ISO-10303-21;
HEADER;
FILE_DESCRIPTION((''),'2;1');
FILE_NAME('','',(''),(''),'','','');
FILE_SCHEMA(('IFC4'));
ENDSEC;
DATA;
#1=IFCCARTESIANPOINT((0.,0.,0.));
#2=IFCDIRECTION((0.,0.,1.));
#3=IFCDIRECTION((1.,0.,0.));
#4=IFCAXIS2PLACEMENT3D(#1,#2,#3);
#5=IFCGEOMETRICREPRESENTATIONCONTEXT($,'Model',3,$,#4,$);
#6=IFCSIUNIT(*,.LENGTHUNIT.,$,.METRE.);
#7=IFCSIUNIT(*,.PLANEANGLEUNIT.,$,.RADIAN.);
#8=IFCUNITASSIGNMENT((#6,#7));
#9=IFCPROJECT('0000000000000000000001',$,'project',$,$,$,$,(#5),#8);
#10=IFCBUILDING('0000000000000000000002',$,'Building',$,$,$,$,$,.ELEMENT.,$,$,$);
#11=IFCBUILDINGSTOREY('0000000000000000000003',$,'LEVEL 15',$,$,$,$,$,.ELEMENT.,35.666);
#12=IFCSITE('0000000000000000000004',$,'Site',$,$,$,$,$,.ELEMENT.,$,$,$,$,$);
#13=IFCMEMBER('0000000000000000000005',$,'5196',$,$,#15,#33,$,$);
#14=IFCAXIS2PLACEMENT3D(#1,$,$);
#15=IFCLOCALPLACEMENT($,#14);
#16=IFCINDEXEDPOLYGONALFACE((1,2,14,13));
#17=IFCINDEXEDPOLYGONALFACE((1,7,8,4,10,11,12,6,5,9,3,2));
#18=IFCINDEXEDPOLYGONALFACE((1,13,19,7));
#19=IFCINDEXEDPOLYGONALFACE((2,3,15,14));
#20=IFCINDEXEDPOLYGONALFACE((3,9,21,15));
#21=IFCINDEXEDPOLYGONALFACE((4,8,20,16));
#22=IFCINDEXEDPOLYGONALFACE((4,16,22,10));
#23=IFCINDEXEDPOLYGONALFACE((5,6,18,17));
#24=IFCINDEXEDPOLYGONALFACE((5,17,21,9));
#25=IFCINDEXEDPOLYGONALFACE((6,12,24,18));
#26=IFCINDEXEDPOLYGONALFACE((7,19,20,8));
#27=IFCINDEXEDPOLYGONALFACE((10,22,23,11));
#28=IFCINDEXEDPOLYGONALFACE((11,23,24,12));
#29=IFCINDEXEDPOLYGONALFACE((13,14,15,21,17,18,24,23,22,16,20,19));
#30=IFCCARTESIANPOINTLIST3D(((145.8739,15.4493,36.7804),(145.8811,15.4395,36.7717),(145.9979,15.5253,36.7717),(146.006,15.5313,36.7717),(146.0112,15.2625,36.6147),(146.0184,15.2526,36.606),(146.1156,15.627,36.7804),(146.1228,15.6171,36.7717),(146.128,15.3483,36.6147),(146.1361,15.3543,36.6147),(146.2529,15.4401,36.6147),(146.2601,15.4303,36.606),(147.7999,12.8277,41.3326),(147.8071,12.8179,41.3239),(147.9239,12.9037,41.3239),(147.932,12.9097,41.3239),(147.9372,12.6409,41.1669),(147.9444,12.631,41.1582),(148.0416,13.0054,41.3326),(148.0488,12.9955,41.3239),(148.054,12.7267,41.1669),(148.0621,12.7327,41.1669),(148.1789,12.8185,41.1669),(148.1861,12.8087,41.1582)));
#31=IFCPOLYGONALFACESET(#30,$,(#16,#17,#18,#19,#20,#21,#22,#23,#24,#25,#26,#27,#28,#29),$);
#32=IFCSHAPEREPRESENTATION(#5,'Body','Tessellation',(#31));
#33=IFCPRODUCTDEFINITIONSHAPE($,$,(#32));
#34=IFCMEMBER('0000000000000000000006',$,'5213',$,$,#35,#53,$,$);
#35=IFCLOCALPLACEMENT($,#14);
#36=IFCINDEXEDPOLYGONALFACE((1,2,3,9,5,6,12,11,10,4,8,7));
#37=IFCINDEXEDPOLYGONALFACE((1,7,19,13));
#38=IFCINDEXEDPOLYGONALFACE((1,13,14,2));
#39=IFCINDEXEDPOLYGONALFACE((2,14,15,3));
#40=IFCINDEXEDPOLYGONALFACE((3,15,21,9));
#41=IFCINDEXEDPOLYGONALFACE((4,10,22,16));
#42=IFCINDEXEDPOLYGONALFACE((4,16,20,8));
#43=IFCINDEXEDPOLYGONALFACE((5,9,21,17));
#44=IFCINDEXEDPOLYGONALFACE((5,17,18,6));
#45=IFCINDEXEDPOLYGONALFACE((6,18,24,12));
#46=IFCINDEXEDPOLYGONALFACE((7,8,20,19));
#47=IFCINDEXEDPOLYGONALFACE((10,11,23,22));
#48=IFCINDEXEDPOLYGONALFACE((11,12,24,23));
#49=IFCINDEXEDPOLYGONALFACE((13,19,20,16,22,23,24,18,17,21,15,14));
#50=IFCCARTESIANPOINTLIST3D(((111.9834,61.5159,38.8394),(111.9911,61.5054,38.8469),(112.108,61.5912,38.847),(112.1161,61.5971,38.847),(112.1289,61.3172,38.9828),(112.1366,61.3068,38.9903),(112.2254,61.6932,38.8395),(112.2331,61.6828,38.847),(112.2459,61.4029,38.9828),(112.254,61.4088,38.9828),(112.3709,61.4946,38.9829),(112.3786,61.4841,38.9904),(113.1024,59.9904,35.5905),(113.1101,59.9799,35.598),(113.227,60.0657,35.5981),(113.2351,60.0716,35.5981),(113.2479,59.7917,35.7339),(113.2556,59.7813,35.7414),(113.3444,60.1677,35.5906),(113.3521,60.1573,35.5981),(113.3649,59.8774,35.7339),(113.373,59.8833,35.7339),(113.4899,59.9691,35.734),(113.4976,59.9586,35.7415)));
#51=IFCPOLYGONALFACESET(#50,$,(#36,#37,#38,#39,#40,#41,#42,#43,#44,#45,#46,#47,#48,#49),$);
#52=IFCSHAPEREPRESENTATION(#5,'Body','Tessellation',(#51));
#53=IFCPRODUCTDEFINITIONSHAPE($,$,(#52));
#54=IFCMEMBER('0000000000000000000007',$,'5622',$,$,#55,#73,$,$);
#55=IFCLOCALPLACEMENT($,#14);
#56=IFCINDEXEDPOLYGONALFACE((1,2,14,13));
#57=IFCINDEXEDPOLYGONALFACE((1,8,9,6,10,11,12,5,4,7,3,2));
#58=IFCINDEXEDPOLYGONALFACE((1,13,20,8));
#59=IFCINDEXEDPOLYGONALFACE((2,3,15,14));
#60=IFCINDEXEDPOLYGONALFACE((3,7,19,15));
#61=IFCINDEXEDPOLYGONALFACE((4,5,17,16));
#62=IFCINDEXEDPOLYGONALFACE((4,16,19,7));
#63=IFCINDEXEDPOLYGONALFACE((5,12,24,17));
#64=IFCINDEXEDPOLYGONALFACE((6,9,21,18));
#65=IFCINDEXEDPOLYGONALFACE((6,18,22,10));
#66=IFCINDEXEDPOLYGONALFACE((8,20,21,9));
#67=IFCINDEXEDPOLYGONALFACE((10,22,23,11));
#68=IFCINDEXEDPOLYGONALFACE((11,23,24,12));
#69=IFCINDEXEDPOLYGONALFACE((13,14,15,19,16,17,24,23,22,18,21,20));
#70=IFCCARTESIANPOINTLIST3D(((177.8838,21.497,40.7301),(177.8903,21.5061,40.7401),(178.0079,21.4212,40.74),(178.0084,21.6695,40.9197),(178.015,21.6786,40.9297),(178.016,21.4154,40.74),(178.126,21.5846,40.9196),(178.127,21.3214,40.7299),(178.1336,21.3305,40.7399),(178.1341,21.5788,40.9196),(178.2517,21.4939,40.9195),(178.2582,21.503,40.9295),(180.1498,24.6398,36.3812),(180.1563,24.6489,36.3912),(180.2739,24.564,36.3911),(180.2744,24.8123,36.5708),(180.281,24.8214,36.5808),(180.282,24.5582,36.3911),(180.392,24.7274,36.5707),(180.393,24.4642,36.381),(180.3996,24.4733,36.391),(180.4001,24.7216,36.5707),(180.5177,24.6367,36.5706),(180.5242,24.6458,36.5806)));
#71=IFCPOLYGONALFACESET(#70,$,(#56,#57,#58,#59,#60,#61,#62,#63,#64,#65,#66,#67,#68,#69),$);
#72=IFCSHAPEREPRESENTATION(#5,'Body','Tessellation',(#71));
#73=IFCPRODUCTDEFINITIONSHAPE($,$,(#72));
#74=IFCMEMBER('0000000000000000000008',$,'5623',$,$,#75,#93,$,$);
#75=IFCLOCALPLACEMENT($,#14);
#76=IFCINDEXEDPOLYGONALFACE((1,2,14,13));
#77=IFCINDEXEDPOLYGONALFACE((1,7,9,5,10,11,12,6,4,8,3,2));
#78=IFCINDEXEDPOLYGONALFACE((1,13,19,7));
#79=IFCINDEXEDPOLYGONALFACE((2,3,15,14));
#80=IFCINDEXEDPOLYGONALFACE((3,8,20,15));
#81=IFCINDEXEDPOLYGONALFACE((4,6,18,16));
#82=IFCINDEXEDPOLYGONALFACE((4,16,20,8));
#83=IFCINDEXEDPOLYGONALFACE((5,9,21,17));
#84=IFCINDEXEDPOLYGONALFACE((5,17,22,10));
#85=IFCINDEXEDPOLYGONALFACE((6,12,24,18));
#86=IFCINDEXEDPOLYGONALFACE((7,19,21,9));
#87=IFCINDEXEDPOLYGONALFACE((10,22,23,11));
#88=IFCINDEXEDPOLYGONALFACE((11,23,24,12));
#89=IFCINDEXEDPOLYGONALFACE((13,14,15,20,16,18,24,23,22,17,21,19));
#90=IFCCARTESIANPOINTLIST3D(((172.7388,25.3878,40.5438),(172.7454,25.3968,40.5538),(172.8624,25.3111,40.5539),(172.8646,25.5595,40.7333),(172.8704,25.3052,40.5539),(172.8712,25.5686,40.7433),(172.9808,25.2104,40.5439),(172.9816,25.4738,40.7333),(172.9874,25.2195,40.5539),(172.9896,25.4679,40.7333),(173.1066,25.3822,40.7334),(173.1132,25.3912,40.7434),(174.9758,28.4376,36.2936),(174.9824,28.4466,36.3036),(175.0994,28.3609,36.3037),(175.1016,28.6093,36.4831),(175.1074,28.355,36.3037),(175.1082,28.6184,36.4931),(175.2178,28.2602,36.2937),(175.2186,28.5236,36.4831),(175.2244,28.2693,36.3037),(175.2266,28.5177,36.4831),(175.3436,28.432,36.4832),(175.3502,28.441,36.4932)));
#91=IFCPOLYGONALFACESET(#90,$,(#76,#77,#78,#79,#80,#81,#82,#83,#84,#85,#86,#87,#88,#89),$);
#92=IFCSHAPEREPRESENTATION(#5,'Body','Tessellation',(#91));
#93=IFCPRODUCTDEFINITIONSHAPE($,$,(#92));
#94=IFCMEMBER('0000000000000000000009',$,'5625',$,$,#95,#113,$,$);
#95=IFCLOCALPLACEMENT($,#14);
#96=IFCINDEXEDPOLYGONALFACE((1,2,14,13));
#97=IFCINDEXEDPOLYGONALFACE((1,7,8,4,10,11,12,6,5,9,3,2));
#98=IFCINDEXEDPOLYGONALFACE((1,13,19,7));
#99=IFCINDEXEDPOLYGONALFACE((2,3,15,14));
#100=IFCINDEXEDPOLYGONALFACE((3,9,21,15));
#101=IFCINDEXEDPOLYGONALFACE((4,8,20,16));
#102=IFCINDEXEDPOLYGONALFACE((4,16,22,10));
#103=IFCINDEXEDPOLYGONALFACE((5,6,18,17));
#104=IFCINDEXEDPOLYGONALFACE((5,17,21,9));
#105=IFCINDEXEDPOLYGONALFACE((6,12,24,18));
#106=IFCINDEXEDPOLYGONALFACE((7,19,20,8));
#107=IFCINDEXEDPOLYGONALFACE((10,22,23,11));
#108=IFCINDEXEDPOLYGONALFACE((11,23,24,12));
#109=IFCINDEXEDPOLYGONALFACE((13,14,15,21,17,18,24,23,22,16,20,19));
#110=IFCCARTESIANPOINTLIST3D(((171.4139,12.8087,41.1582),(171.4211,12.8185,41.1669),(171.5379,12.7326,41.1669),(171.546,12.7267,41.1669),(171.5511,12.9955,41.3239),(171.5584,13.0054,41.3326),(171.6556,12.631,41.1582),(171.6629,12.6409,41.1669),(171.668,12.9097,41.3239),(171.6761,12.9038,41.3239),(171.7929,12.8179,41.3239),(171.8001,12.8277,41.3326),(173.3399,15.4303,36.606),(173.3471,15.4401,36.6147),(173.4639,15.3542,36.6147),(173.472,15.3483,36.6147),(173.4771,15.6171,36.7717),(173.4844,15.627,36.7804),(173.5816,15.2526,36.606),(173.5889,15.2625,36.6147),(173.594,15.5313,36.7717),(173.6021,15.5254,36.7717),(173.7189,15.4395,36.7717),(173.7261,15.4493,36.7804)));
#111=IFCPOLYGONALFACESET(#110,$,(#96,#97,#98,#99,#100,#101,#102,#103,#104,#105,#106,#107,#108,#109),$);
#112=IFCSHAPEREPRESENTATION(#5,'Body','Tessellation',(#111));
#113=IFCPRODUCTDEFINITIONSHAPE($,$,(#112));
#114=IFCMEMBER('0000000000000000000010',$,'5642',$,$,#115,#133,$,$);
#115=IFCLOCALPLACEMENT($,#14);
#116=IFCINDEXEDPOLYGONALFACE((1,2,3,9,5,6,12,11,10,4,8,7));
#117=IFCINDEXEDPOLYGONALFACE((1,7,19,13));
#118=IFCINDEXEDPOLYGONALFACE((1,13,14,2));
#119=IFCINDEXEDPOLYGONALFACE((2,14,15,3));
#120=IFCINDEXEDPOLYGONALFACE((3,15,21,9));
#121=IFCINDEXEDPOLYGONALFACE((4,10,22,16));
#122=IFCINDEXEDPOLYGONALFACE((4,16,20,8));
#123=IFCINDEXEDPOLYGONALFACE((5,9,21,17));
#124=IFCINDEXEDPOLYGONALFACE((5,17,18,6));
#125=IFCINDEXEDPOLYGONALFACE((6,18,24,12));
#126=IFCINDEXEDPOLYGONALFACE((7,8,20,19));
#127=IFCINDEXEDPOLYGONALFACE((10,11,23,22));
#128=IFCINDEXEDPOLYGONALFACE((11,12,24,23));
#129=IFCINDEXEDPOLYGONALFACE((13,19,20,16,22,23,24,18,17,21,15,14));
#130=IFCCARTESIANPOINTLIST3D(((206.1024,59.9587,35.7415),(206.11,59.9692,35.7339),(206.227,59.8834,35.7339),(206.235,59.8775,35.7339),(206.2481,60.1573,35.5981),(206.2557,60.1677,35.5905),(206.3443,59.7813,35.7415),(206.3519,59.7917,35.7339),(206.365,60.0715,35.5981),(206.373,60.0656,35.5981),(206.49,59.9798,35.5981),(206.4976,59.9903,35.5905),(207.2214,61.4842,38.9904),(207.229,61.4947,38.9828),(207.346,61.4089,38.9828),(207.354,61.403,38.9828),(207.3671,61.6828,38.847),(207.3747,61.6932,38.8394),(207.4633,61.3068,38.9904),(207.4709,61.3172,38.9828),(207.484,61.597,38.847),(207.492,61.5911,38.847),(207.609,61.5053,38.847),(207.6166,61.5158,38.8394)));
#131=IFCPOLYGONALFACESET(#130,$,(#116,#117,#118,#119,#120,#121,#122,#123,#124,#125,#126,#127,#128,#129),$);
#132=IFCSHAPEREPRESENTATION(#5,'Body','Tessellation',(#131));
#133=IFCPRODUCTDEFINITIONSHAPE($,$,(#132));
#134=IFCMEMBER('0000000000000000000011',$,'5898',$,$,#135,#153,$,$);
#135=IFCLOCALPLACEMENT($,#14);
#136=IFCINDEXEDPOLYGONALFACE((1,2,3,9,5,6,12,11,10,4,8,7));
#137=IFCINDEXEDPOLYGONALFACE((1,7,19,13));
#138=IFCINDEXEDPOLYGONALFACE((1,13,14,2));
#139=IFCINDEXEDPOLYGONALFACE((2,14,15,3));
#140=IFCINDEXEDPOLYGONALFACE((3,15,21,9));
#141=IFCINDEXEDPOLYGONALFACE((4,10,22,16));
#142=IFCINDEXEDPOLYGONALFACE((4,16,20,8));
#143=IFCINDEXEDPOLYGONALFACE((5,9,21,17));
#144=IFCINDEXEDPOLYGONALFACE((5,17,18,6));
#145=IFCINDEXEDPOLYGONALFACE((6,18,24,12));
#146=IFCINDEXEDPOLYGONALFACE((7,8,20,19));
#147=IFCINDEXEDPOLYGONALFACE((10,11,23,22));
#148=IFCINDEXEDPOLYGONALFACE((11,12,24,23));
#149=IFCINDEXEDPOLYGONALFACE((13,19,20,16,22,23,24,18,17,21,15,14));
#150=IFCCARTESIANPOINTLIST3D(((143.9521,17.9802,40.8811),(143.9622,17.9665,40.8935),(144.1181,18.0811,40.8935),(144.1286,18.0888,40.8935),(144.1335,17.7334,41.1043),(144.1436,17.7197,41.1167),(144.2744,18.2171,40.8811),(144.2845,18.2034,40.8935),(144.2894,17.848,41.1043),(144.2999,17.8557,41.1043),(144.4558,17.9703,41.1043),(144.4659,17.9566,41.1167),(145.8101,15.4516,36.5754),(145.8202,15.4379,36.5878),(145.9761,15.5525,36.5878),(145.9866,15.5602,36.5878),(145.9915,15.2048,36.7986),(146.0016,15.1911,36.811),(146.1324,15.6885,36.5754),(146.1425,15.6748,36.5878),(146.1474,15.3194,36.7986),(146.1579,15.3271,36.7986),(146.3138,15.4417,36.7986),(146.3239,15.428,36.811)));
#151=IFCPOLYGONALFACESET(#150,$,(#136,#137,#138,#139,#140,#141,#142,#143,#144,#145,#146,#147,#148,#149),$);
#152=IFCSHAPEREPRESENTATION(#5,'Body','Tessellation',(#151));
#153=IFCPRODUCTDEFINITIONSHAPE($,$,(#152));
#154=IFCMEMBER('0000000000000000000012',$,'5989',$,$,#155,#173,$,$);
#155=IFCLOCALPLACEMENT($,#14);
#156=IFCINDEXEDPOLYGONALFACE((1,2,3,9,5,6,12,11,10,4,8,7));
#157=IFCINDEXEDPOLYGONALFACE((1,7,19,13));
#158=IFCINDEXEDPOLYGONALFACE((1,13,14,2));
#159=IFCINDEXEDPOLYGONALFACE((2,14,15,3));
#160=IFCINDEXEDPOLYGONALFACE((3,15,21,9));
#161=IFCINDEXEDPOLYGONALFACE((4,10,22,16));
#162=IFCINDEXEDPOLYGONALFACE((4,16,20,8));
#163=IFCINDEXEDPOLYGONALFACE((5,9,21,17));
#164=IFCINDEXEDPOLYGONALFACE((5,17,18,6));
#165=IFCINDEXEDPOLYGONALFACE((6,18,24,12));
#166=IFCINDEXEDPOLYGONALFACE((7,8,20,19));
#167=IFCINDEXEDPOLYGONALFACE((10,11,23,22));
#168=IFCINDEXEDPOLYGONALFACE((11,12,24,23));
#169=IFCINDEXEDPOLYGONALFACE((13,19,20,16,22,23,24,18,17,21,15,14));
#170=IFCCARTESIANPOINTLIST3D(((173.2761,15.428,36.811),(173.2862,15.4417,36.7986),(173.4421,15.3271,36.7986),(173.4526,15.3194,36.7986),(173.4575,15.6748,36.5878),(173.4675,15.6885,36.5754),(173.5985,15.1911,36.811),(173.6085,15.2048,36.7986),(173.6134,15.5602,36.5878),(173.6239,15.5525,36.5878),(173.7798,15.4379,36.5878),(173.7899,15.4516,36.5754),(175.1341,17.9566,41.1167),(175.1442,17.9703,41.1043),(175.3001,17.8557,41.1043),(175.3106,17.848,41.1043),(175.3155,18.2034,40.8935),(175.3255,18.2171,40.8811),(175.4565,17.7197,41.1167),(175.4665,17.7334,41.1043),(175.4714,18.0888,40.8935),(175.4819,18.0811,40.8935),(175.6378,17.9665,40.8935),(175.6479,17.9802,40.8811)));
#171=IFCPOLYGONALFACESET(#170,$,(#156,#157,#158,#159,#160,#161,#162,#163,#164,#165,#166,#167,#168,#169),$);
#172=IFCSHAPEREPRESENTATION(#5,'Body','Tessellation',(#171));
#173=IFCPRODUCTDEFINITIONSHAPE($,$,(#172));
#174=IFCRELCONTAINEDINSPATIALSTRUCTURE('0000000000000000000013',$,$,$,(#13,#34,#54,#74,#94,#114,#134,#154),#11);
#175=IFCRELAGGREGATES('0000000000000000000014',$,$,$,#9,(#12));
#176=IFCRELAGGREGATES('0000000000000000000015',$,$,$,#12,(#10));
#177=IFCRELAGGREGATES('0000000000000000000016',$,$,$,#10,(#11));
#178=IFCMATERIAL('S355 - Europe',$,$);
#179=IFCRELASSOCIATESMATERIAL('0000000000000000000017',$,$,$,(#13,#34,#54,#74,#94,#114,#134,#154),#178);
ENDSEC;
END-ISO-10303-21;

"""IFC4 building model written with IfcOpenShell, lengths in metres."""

from ifc_helpers import new_model, si_unit, frame, origin_with_axes, origin_2d_with_axis, place, context, project, spatial, i_section, extrude, material, material_profile, profile_set, profile_usage, element, save


model = new_model("IFC4")

# Units and contexts
model_context = context("Model", 3, world=origin_with_axes())
ifc_project = project(units=[si_unit("LENGTHUNIT", "METRE"), si_unit("PLANEANGLEUNIT", "RADIAN")], contexts=[model_context])

# Site, building, storey
site = spatial("IfcSite", under=ifc_project, Name="Site", CompositionType="ELEMENT")
building = spatial("IfcBuilding", under=site, Name="Building", CompositionType="ELEMENT")
storey = spatial("IfcBuildingStorey", under=building, Name="LEVEL 15", CompositionType="ELEMENT", Elevation=35.666)

# Shared definitions
ifc_material = material(Name="S355 - Europe")

# Members
ifc_material_profile_1 = material_profile(ifc_material, i_section(OverallWidth=0.3, OverallDepth=0.3, WebThickness=0.01, FlangeThickness=0.015, at=origin_2d_with_axis()))
ifc_profile_set_1 = profile_set([ifc_material_profile_1])
ifc_profile_usage_1 = profile_usage(ifc_profile_set_1, cardinal=10)
member_1_placement = place(None, frame((146.067, 15.4398, 36.6932), z_axis=(0.344232, -0.468556, 0.813609), x_axis=(0.805798, 0.59219, 0.0)))
element("IfcMember", 1, at=member_1_placement, inside=storey, material=ifc_profile_usage_1, Name="5196", context=model_context, shape_type="SweptSolid", body=[
    extrude(i_section(OverallWidth=0.3, OverallDepth=0.3, WebThickness=0.01, FlangeThickness=0.015, at=origin_2d_with_axis()), origin_with_axes(), (0.0, 0.0, 1.0), 5.5951),
])
ifc_material_profile_2 = material_profile(ifc_material, i_section(OverallWidth=0.3, OverallDepth=0.3, WebThickness=0.01, FlangeThickness=0.015, at=origin_2d_with_axis()))
ifc_profile_set_2 = profile_set([ifc_material_profile_2])
ifc_profile_usage_2 = profile_usage(ifc_profile_set_2, cardinal=10)
member_2_placement = place(None, frame((113.3, 59.9745, 35.666), z_axis=(-0.297637, 0.40576, 0.864159), x_axis=(-0.806706, -0.590953, 0.0)))
element("IfcMember", 2, at=member_2_placement, inside=storey, material=ifc_profile_usage_2, Name="5213", context=model_context, shape_type="SweptSolid", body=[
    extrude(i_section(OverallWidth=0.3, OverallDepth=0.3, WebThickness=0.01, FlangeThickness=0.015, at=origin_2d_with_axis()), origin_with_axes(), (0.0, 0.0, 1.0), 3.7596),
])
ifc_material_profile_3 = material_profile(ifc_material, i_section(OverallWidth=0.3, OverallDepth=0.3, WebThickness=0.01, FlangeThickness=0.015, at=origin_2d_with_axis()))
ifc_profile_set_3 = profile_set([ifc_material_profile_3])
ifc_profile_usage_3 = profile_usage(ifc_profile_set_3, cardinal=10)
member_3_placement = place(None, frame((180.337, 24.6428, 36.4809), z_axis=(-0.389046, -0.539582, 0.746656), x_axis=(0.810475, -0.585773, 0.0)))
element("IfcMember", 3, at=member_3_placement, inside=storey, material=ifc_profile_usage_3, Name="5622", context=model_context, shape_type="SweptSolid", body=[
    extrude(i_section(OverallWidth=0.3, OverallDepth=0.3, WebThickness=0.01, FlangeThickness=0.015, at=origin_2d_with_axis()), origin_with_axes(), (0.0, 0.0, 1.0), 5.8245),
])
ifc_material_profile_4 = material_profile(ifc_material, i_section(OverallWidth=0.3, OverallDepth=0.3, WebThickness=0.01, FlangeThickness=0.015, at=origin_2d_with_axis()))
ifc_profile_set_4 = profile_set([ifc_material_profile_4])
ifc_profile_usage_4 = profile_usage(ifc_profile_set_4, cardinal=10)
member_4_placement = place(None, frame((175.163, 28.4393, 36.3934), z_axis=(-0.393185, -0.536046, 0.747034), x_axis=(0.806706, -0.590953, 0.0)))
element("IfcMember", 4, at=member_4_placement, inside=storey, material=ifc_profile_usage_4, Name="5623", context=model_context, shape_type="SweptSolid", body=[
    extrude(i_section(OverallWidth=0.3, OverallDepth=0.3, WebThickness=0.01, FlangeThickness=0.015, at=origin_2d_with_axis()), origin_with_axes(), (0.0, 0.0, 1.0), 5.6894),
])
ifc_material_profile_5 = material_profile(ifc_material, i_section(OverallWidth=0.3, OverallDepth=0.3, WebThickness=0.01, FlangeThickness=0.015, at=origin_2d_with_axis()))
ifc_profile_set_5 = profile_set([ifc_material_profile_5])
ifc_profile_usage_5 = profile_usage(ifc_profile_set_5, cardinal=10)
member_5_placement = place(None, frame((173.533, 15.4398, 36.6932), z_axis=(-0.344232, -0.468556, 0.813609), x_axis=(0.805899, -0.592052, 0.0)))
element("IfcMember", 5, at=member_5_placement, inside=storey, material=ifc_profile_usage_5, Name="5625", context=model_context, shape_type="SweptSolid", body=[
    extrude(i_section(OverallWidth=0.3, OverallDepth=0.3, WebThickness=0.01, FlangeThickness=0.015, at=origin_2d_with_axis()), origin_with_axes(), (0.0, 0.0, 1.0), 5.5951),
])
ifc_material_profile_6 = material_profile(ifc_material, i_section(OverallWidth=0.3, OverallDepth=0.3, WebThickness=0.01, FlangeThickness=0.015, at=origin_2d_with_axis()))
ifc_profile_set_6 = profile_set([ifc_material_profile_6])
ifc_profile_usage_6 = profile_usage(ifc_profile_set_6, cardinal=10)
member_6_placement = place(None, frame((206.3, 59.9745, 35.666), z_axis=(0.297637, 0.40576, 0.864159), x_axis=(-0.806237, 0.591593, 0.0)))
element("IfcMember", 6, at=member_6_placement, inside=storey, material=ifc_profile_usage_6, Name="5642", context=model_context, shape_type="SweptSolid", body=[
    extrude(i_section(OverallWidth=0.3, OverallDepth=0.3, WebThickness=0.01, FlangeThickness=0.015, at=origin_2d_with_axis()), origin_with_axes(), (0.0, 0.0, 1.0), 3.7596),
])
ifc_material_profile_7 = material_profile(ifc_material, i_section(OverallWidth=0.4, OverallDepth=0.4, WebThickness=0.013, FlangeThickness=0.021, at=origin_2d_with_axis()))
ifc_profile_set_7 = profile_set([ifc_material_profile_7])
ifc_profile_usage_7 = profile_usage(ifc_profile_set_7, cardinal=10)
member_7_placement = place(None, frame((146.067, 15.4398, 36.6932), z_axis=(-0.348739, 0.474608, 0.808163), x_axis=(-0.805765, -0.592235, 0.0)))
element("IfcMember", 7, at=member_7_placement, inside=storey, material=ifc_profile_usage_7, Name="5898", context=model_context, shape_type="SweptSolid", body=[
    extrude(i_section(OverallWidth=0.4, OverallDepth=0.4, WebThickness=0.013, FlangeThickness=0.021, at=origin_2d_with_axis()), origin_with_axes(), (0.0, 0.0, 1.0), 5.3278),
])
ifc_material_profile_8 = material_profile(ifc_material, i_section(OverallWidth=0.4, OverallDepth=0.4, WebThickness=0.013, FlangeThickness=0.021, at=origin_2d_with_axis()))
ifc_profile_set_8 = profile_set([ifc_material_profile_8])
ifc_profile_usage_8 = profile_usage(ifc_profile_set_8, cardinal=10)
member_8_placement = place(None, frame((173.533, 15.4398, 36.6932), z_axis=(0.348739, 0.474608, 0.808163), x_axis=(-0.805846, 0.592125, 0.0)))
element("IfcMember", 8, at=member_8_placement, inside=storey, material=ifc_profile_usage_8, Name="5989", context=model_context, shape_type="SweptSolid", body=[
    extrude(i_section(OverallWidth=0.4, OverallDepth=0.4, WebThickness=0.013, FlangeThickness=0.021, at=origin_2d_with_axis()), origin_with_axes(), (0.0, 0.0, 1.0), 5.3278),
])

save(model, "model.ifc")
